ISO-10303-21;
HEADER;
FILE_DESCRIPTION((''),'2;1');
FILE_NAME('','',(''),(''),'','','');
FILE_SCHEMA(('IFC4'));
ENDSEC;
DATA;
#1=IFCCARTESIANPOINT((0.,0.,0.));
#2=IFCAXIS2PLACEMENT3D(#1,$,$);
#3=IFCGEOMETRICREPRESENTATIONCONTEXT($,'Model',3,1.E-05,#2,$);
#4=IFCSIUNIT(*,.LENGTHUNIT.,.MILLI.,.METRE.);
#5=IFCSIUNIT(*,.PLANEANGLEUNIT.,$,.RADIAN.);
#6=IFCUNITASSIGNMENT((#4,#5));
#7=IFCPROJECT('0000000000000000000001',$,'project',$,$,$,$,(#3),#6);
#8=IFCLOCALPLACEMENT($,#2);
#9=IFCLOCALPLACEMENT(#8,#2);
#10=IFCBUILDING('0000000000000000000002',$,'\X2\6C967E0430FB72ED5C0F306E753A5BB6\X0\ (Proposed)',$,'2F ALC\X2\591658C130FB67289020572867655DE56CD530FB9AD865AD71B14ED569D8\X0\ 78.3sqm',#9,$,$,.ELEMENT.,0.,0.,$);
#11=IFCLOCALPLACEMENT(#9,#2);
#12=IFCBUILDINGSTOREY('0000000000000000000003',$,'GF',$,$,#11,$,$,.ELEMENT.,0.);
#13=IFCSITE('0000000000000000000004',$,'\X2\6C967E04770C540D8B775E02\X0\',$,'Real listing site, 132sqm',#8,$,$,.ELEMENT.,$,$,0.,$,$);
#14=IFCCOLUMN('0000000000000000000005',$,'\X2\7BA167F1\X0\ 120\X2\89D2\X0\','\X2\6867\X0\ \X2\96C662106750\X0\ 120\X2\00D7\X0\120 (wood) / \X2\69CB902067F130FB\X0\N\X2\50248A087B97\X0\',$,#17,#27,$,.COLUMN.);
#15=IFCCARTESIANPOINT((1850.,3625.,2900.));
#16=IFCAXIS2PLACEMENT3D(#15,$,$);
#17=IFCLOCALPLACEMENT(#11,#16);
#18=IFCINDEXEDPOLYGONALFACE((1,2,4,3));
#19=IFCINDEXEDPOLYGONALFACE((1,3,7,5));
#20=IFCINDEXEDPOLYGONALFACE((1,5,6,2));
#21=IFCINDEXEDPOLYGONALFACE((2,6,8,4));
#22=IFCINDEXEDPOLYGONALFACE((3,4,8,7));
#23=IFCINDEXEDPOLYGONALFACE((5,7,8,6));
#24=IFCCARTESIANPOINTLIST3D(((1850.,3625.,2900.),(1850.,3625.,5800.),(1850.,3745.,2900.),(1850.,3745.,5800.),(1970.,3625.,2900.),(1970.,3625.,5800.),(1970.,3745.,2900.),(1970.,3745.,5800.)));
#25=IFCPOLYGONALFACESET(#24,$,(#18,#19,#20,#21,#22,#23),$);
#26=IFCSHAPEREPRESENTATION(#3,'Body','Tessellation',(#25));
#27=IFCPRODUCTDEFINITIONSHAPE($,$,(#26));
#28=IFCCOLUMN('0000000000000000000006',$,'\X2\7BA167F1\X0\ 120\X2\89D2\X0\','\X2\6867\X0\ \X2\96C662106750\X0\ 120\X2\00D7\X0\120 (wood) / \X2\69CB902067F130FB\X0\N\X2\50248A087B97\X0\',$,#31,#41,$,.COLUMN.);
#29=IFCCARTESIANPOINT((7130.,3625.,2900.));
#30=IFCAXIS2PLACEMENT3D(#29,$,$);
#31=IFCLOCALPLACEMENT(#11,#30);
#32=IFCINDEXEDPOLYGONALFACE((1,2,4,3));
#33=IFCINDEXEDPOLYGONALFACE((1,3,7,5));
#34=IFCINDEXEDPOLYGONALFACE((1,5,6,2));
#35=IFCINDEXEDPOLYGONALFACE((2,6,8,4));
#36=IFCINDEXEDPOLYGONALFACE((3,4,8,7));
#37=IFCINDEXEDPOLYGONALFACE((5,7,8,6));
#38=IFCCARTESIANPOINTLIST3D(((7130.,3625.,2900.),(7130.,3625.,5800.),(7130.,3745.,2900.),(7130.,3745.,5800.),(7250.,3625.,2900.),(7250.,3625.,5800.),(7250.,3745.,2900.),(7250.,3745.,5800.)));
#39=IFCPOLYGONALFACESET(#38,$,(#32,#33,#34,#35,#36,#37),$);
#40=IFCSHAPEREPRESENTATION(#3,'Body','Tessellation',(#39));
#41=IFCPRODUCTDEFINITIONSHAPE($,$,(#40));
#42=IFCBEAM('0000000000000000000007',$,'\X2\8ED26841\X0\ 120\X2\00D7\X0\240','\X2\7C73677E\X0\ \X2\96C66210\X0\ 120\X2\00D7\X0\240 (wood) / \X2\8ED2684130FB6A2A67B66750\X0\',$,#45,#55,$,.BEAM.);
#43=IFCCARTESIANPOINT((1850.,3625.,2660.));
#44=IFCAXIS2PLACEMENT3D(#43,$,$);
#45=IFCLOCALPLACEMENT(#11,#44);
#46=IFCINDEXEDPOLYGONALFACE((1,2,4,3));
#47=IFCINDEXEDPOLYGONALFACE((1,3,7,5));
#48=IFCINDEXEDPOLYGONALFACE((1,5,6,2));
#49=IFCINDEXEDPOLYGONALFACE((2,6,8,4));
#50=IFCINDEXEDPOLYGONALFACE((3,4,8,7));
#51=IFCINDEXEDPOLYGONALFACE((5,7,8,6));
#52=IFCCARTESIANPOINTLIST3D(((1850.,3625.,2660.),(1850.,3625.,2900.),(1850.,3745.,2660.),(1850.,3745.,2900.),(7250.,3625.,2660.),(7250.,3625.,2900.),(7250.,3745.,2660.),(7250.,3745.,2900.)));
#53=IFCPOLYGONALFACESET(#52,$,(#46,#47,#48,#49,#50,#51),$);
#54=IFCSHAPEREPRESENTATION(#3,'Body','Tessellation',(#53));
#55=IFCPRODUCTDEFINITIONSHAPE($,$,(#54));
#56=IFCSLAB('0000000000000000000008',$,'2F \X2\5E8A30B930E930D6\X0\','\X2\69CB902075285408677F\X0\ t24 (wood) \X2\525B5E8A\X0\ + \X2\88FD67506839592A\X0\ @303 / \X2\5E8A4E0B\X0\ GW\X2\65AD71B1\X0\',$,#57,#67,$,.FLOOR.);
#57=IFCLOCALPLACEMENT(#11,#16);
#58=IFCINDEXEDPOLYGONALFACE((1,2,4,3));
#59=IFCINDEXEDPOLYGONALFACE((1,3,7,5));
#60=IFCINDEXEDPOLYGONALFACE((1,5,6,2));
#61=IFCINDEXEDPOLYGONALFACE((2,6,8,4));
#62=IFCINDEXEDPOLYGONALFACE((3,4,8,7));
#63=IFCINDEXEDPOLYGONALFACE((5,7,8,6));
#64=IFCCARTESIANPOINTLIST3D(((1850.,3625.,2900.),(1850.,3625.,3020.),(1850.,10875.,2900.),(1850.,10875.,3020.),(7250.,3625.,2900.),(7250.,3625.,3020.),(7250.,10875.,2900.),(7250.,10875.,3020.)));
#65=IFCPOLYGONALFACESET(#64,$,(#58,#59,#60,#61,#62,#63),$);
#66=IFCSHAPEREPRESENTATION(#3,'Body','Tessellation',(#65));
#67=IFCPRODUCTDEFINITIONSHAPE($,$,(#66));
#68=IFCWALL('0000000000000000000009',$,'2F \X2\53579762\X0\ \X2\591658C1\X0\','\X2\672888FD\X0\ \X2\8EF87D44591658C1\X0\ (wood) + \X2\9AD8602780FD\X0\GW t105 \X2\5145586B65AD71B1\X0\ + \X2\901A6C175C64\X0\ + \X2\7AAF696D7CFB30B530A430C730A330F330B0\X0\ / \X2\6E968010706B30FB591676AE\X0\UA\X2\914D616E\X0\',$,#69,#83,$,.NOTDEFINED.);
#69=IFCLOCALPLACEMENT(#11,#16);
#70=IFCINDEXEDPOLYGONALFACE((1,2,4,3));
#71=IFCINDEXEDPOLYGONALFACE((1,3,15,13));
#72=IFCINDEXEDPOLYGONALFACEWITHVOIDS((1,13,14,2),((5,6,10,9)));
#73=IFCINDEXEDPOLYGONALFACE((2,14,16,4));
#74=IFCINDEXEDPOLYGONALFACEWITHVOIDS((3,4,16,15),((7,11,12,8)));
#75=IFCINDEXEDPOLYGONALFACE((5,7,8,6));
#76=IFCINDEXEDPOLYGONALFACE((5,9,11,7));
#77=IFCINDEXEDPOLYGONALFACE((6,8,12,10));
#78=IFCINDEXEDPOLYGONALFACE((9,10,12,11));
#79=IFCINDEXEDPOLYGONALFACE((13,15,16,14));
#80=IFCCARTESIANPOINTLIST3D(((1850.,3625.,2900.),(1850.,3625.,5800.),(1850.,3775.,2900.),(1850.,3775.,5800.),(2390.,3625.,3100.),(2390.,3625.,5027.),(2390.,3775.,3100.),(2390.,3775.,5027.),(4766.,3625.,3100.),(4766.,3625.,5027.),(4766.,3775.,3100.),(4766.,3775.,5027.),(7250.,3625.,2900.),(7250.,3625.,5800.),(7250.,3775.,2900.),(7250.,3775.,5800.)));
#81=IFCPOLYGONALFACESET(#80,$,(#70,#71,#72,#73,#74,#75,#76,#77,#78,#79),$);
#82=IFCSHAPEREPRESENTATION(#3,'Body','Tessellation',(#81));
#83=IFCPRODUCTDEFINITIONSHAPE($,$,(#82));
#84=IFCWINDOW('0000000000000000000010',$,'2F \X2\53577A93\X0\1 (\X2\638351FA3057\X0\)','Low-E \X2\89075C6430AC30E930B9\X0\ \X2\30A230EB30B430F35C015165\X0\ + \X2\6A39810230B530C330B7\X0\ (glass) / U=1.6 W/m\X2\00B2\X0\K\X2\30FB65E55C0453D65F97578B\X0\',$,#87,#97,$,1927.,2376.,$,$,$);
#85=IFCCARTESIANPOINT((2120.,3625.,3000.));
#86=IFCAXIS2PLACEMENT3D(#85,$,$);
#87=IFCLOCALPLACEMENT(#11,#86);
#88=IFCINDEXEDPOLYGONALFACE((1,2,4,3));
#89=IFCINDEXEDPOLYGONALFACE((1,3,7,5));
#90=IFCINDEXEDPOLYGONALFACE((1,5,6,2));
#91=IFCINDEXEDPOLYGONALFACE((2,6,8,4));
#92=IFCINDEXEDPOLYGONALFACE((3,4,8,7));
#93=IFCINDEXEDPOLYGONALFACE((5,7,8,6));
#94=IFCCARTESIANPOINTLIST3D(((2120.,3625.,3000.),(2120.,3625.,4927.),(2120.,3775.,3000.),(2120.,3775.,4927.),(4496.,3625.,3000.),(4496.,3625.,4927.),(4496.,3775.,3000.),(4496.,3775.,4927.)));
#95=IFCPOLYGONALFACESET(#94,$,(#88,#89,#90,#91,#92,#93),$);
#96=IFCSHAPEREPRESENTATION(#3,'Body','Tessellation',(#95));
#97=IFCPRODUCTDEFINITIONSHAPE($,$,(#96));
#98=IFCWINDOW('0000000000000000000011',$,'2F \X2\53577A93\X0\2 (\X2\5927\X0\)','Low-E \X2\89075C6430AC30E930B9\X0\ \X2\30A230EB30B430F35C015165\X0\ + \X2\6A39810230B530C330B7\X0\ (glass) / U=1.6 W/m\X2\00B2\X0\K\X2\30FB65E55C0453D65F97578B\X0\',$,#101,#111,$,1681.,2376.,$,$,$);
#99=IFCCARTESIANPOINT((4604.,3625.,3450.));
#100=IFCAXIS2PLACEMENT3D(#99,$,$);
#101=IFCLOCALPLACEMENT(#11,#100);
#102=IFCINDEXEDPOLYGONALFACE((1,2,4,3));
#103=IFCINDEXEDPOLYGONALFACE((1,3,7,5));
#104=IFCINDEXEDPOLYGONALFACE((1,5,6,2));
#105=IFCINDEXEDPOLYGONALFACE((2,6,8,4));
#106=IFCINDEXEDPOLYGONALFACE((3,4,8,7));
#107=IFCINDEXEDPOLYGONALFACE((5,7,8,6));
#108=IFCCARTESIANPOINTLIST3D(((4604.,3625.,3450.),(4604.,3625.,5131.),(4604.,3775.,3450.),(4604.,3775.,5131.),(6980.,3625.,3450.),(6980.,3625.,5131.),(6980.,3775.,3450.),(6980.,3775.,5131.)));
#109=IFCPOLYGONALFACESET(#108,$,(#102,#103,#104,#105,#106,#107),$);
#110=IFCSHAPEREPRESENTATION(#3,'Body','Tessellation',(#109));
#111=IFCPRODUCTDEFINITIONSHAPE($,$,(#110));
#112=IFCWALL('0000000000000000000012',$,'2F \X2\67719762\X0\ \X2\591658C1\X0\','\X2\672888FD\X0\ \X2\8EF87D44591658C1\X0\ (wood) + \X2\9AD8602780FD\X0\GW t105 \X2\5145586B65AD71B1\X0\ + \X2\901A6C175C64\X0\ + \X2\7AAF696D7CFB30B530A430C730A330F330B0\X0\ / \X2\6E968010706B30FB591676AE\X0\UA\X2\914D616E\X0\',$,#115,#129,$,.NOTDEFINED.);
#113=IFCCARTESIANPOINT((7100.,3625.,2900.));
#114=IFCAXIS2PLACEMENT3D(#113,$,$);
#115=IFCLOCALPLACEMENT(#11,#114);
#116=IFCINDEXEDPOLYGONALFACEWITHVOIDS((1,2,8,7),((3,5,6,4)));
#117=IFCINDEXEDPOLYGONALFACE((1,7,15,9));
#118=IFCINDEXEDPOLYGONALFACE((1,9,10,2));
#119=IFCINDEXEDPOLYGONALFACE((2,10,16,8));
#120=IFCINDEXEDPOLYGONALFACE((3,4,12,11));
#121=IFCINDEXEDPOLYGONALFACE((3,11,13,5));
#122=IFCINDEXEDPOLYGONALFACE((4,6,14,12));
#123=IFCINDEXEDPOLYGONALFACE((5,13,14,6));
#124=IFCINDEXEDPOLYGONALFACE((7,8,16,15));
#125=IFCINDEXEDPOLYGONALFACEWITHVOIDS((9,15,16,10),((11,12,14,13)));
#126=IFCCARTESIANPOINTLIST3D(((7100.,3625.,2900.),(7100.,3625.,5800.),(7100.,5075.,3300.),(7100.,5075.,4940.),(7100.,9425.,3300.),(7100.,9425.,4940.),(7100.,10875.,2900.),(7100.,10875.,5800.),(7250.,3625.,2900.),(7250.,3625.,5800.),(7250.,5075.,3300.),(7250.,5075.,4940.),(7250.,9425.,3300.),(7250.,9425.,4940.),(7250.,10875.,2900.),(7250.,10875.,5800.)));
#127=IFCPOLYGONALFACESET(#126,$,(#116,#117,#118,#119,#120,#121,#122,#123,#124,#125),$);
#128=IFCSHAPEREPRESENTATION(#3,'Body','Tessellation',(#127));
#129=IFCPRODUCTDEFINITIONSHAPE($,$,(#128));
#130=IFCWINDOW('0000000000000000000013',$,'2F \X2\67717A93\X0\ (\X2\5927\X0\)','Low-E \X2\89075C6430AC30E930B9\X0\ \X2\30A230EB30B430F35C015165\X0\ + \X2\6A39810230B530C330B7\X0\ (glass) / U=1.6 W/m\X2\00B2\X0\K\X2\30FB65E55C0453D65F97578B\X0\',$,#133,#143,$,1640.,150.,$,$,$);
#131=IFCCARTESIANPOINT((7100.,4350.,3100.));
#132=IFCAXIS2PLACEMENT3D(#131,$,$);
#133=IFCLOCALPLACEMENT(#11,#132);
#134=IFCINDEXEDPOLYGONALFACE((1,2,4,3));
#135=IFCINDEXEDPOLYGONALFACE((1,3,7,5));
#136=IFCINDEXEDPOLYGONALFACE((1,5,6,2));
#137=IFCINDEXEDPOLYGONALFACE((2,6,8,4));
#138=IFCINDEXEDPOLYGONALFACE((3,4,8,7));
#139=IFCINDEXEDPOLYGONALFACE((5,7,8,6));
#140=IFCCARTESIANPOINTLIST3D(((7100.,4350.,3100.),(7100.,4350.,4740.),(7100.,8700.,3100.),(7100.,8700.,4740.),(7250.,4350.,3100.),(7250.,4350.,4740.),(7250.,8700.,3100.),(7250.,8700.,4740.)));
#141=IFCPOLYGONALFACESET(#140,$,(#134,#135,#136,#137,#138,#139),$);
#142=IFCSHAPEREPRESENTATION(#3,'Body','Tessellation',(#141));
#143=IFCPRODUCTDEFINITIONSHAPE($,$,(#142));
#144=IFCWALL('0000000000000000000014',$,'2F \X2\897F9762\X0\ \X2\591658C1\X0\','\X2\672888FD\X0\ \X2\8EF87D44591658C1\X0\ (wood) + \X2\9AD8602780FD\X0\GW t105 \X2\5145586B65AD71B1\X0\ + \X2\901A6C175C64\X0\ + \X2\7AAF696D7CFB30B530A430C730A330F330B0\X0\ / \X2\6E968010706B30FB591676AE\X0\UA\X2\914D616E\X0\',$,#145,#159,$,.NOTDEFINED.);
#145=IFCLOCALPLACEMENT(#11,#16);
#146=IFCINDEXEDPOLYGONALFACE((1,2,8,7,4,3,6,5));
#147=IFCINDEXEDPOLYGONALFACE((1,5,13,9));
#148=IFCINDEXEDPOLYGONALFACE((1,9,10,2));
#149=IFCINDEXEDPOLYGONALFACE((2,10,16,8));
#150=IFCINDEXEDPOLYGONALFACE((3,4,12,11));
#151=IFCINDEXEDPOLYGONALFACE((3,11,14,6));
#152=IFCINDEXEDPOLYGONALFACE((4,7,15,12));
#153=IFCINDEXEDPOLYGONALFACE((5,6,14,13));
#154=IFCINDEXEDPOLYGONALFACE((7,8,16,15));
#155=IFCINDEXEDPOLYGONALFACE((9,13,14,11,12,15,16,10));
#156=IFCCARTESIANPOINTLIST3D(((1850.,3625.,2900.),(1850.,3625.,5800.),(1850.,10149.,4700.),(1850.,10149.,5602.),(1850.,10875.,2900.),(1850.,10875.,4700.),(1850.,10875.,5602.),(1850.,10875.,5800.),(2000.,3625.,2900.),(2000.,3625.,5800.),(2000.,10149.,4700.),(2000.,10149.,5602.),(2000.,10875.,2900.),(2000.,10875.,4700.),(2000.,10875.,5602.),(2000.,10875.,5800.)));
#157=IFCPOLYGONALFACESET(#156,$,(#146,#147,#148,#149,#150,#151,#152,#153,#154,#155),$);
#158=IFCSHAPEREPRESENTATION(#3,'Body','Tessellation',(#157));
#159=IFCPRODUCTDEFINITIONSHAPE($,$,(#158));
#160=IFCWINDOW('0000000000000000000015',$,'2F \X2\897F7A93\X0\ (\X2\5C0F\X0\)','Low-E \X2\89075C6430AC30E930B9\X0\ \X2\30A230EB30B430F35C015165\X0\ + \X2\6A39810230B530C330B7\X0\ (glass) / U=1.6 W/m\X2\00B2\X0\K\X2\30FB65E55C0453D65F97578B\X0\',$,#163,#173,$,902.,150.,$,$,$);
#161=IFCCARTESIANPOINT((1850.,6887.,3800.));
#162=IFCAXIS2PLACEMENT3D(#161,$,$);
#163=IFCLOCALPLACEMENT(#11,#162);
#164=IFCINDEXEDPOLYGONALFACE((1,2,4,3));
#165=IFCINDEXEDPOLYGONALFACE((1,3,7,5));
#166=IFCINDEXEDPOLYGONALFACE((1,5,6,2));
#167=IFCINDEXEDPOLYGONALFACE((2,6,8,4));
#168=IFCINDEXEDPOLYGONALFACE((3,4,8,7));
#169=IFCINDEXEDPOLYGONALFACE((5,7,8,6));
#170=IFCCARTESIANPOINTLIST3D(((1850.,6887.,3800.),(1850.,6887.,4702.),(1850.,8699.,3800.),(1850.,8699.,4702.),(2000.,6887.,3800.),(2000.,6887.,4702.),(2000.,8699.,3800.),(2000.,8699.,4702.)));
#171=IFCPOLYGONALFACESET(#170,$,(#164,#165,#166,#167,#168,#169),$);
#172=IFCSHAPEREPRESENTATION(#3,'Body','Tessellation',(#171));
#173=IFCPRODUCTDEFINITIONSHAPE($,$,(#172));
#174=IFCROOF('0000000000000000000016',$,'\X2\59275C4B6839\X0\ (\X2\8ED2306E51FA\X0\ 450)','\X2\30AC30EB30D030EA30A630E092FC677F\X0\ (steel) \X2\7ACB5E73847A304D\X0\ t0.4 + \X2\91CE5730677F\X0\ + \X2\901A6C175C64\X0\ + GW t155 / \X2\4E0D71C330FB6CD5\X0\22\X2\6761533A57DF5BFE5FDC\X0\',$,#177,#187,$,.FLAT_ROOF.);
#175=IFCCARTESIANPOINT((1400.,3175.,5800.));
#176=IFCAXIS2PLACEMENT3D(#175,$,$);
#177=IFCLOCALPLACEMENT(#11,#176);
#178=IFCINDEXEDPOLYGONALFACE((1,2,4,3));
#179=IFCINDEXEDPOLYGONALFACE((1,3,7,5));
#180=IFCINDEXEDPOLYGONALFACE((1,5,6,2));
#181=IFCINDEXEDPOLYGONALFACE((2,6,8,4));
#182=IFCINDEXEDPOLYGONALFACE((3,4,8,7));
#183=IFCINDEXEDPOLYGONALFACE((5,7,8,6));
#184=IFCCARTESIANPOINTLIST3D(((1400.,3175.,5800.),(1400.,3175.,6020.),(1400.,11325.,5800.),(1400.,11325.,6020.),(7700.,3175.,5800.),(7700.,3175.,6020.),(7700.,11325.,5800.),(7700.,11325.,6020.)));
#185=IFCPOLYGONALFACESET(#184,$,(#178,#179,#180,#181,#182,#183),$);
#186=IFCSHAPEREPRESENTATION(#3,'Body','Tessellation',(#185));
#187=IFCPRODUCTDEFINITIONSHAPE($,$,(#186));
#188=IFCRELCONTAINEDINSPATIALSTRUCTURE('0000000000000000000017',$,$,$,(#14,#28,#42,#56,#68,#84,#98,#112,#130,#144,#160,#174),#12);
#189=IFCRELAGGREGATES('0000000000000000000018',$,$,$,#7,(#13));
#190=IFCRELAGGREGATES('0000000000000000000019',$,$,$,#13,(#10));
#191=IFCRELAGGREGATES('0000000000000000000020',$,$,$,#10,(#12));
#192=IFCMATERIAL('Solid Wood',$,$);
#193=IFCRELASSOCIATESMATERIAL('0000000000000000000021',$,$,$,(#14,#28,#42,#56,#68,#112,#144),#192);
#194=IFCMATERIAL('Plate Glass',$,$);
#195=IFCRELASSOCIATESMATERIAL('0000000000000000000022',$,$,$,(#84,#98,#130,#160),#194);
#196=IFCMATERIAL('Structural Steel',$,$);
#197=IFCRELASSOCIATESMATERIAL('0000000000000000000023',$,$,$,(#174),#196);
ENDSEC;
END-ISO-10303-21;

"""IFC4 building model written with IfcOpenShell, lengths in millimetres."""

from ifc_helpers import new_model, si_unit, frame, frame_2d, origin, place, context, project, spatial, rectangle, extrude, material, element, fill, save


model = new_model("IFC4")

# Units and contexts
model_context = context("Model", 3, precision=1e-05, world=origin())
ifc_project = project(units=[si_unit("LENGTHUNIT", "METRE", prefix="MILLI"), si_unit("PLANEANGLEUNIT", "RADIAN")], contexts=[model_context])

# Site, building, storey
site_placement = place(None, origin())
site = spatial("IfcSite", under=ifc_project, at=site_placement, Name="沖縄県名護市", ObjectType="Real listing site, 132sqm", CompositionType="ELEMENT", RefElevation=0.0)
building_placement = place(site_placement, origin())
building = spatial("IfcBuilding", under=site, at=building_placement, Name="沖縄・狭小の町家 (Proposed)", ObjectType="2F ALC外壁・木造在来工法・高断熱仕様 78.3sqm", CompositionType="ELEMENT", ElevationOfRefHeight=0.0, ElevationOfTerrain=0.0)
storey_placement = place(building_placement, origin())
storey = spatial("IfcBuildingStorey", under=building, at=storey_placement, Name="GF", CompositionType="ELEMENT", Elevation=0.0)

# Columns
ifc_material_1 = material(Name="Solid Wood")
column_1_placement = place(storey_placement, frame((1850.0, 3625.0, 2900.0)))
element("IfcColumn", 1, at=column_1_placement, inside=storey, material=ifc_material_1, Name="管柱 120角", Description="桧 集成材 120×120 (wood) / 構造柱・N値計算", PredefinedType="COLUMN", context=model_context, shape_type="SweptSolid", body=[
    extrude(rectangle(XDim=120.0, YDim=120.0, at=frame_2d((60.0, 60.0))), frame((1850.0, 3625.0, 2900.0)), (0.0, 0.0, 1.0), 2900.0),
])
column_2_placement = place(storey_placement, frame((7130.0, 3625.0, 2900.0)))
element("IfcColumn", 2, at=column_2_placement, inside=storey, material=ifc_material_1, Name="管柱 120角", Description="桧 集成材 120×120 (wood) / 構造柱・N値計算", PredefinedType="COLUMN", context=model_context, shape_type="SweptSolid", body=[
    extrude(rectangle(XDim=120.0, YDim=120.0, at=frame_2d((60.0, 60.0))), frame((7130.0, 3625.0, 2900.0)), (0.0, 0.0, 1.0), 2900.0),
])

# Beam
beam_1_placement = place(storey_placement, frame((1850.0, 3625.0, 2660.0)))
element("IfcBeam", 3, at=beam_1_placement, inside=storey, material=ifc_material_1, Name="軒桁 120×240", Description="米松 集成 120×240 (wood) / 軒桁・横架材", PredefinedType="BEAM", context=model_context, shape_type="SweptSolid", body=[
    extrude(rectangle(XDim=5400.0, YDim=120.0, at=frame_2d((2700.0, 60.0))), frame((1850.0, 3625.0, 2660.0)), (0.0, 0.0, 1.0), 240.0),
])

# Slab
slab_placement = place(storey_placement, frame((1850.0, 3625.0, 2900.0)))
element("IfcSlab", 4, at=slab_placement, inside=storey, material=ifc_material_1, Name="2F 床スラブ", Description="構造用合板 t24 (wood) 剛床 + 製材根太 @303 / 床下 GW断熱", PredefinedType="FLOOR", context=model_context, shape_type="SweptSolid", body=[
    extrude(rectangle(XDim=5400.0, YDim=7250.0, at=frame_2d((2700.0, 3625.0))), frame((1850.0, 3625.0, 2900.0)), (0.0, 0.0, 1.0), 120.0),
])

# Wall, openings, windows
wall_1_placement = place(storey_placement, frame((1850.0, 3625.0, 2900.0)))
wall_1 = element("IfcWall", 5, at=wall_1_placement, inside=storey, material=ifc_material_1, Name="2F 南面 外壁", Description="木製 軸組外壁 (wood) + 高性能GW t105 充填断熱 + 通気層 + 窯業系サイディング / 準耐火・外皮UA配慮", PredefinedType="NOTDEFINED", context=model_context, shape_type="SweptSolid", body=[
    extrude(rectangle(XDim=5400.0, YDim=150.0, at=frame_2d((2700.0, 75.0))), frame((1850.0, 3625.0, 2900.0)), (0.0, 0.0, 1.0), 2900.0),
])
opening_1_placement = place(storey_placement, frame((2120.0, 3625.0, 3000.0)))
opening_1 = element("IfcOpeningElement", 6, at=opening_1_placement, cuts=wall_1, PredefinedType="NOTDEFINED", context=model_context, shape_type="SweptSolid", body=[
    extrude(rectangle(XDim=2376.0, YDim=150.0, at=frame_2d((1188.0, 75.0))), frame((2120.0, 3625.0, 3000.0)), (0.0, 0.0, 1.0), 1927.0),
])
opening_2_placement = place(storey_placement, frame((4604.0, 3625.0, 3450.0)))
opening_2 = element("IfcOpeningElement", 7, at=opening_2_placement, cuts=wall_1, PredefinedType="NOTDEFINED", context=model_context, shape_type="SweptSolid", body=[
    extrude(rectangle(XDim=2376.0, YDim=150.0, at=frame_2d((1188.0, 75.0))), frame((4604.0, 3625.0, 3450.0)), (0.0, 0.0, 1.0), 1681.0),
])
ifc_material_2 = material(Name="Plate Glass")
window_1_placement = place(storey_placement, frame((2120.0, 3625.0, 3000.0)))
window_1 = element("IfcWindow", 8, at=window_1_placement, inside=storey, material=ifc_material_2, Name="2F 南窓1 (掃出し)", Description="Low-E 複層ガラス アルゴン封入 + 樹脂サッシ (glass) / U=1.6 W/m²K・日射取得型", OverallHeight=1927.0, OverallWidth=2376.0, context=model_context, shape_type="SweptSolid", body=[
    extrude(rectangle(XDim=2376.0, YDim=150.0, at=frame_2d((1188.0, 75.0))), frame((2120.0, 3625.0, 3000.0)), (0.0, 0.0, 1.0), 1927.0),
])
fill(opening_1, window_1)
window_2_placement = place(storey_placement, frame((4604.0, 3625.0, 3450.0)))
window_2 = element("IfcWindow", 9, at=window_2_placement, inside=storey, material=ifc_material_2, Name="2F 南窓2 (大)", Description="Low-E 複層ガラス アルゴン封入 + 樹脂サッシ (glass) / U=1.6 W/m²K・日射取得型", OverallHeight=1681.0, OverallWidth=2376.0, context=model_context, shape_type="SweptSolid", body=[
    extrude(rectangle(XDim=2376.0, YDim=150.0, at=frame_2d((1188.0, 75.0))), frame((4604.0, 3625.0, 3450.0)), (0.0, 0.0, 1.0), 1681.0),
])
fill(opening_2, window_2)

# Walls, openings, windows
wall_2_placement = place(storey_placement, frame((7100.0, 3625.0, 2900.0)))
wall_2 = element("IfcWall", 10, at=wall_2_placement, inside=storey, material=ifc_material_1, Name="2F 東面 外壁", Description="木製 軸組外壁 (wood) + 高性能GW t105 充填断熱 + 通気層 + 窯業系サイディング / 準耐火・外皮UA配慮", PredefinedType="NOTDEFINED", context=model_context, shape_type="SweptSolid", body=[
    extrude(rectangle(XDim=150.0, YDim=7250.0, at=frame_2d((75.0, 3625.0))), frame((7100.0, 3625.0, 2900.0)), (0.0, 0.0, 1.0), 2900.0),
])
opening_3_placement = place(storey_placement, frame((7100.0, 4350.0, 3100.0)))
opening_3 = element("IfcOpeningElement", 11, at=opening_3_placement, cuts=wall_2, PredefinedType="NOTDEFINED", context=model_context, shape_type="SweptSolid", body=[
    extrude(rectangle(XDim=150.0, YDim=4350.0, at=frame_2d((75.0, 2175.0))), frame((7100.0, 4350.0, 3100.0)), (0.0, 0.0, 1.0), 1640.0),
])
window_3_placement = place(storey_placement, frame((7100.0, 4350.0, 3100.0)))
window_3 = element("IfcWindow", 12, at=window_3_placement, inside=storey, material=ifc_material_2, Name="2F 東窓 (大)", Description="Low-E 複層ガラス アルゴン封入 + 樹脂サッシ (glass) / U=1.6 W/m²K・日射取得型", OverallHeight=1640.0, OverallWidth=150.0, context=model_context, shape_type="SweptSolid", body=[
    extrude(rectangle(XDim=150.0, YDim=4350.0, at=frame_2d((75.0, 2175.0))), frame((7100.0, 4350.0, 3100.0)), (0.0, 0.0, 1.0), 1640.0),
])
fill(opening_3, window_3)
wall_3_placement = place(storey_placement, frame((1850.0, 3625.0, 2900.0)))
wall_3 = element("IfcWall", 13, at=wall_3_placement, inside=storey, material=ifc_material_1, Name="2F 西面 外壁", Description="木製 軸組外壁 (wood) + 高性能GW t105 充填断熱 + 通気層 + 窯業系サイディング / 準耐火・外皮UA配慮", PredefinedType="NOTDEFINED", context=model_context, shape_type="SweptSolid", body=[
    extrude(rectangle(XDim=150.0, YDim=7250.0, at=frame_2d((75.0, 3625.0))), frame((1850.0, 3625.0, 2900.0)), (0.0, 0.0, 1.0), 2900.0),
])
opening_4_placement = place(storey_placement, frame((1850.0, 6887.0, 3800.0)))
opening_4 = element("IfcOpeningElement", 14, at=opening_4_placement, cuts=wall_3, PredefinedType="NOTDEFINED", context=model_context, shape_type="SweptSolid", body=[
    extrude(rectangle(XDim=150.0, YDim=1812.0, at=frame_2d((75.0, 906.0))), frame((1850.0, 6887.0, 3800.0)), (0.0, 0.0, 1.0), 902.0),
])
window_4_placement = place(storey_placement, frame((1850.0, 6887.0, 3800.0)))
window_4 = element("IfcWindow", 15, at=window_4_placement, inside=storey, material=ifc_material_2, Name="2F 西窓 (小)", Description="Low-E 複層ガラス アルゴン封入 + 樹脂サッシ (glass) / U=1.6 W/m²K・日射取得型", OverallHeight=902.0, OverallWidth=150.0, context=model_context, shape_type="SweptSolid", body=[
    extrude(rectangle(XDim=150.0, YDim=1812.0, at=frame_2d((75.0, 906.0))), frame((1850.0, 6887.0, 3800.0)), (0.0, 0.0, 1.0), 902.0),
])
fill(opening_4, window_4)

# Roof
ifc_material_3 = material(Name="Structural Steel")
roof_placement = place(storey_placement, frame((1400.0, 3175.0, 5800.0)))
element("IfcRoof", 16, at=roof_placement, inside=storey, material=ifc_material_3, Name="大屋根 (軒の出 450)", Description="ガルバリウム鋼板 (steel) 立平葺き t0.4 + 野地板 + 通気層 + GW t155 / 不燃・法22条区域対応", PredefinedType="FLAT_ROOF", context=model_context, shape_type="SweptSolid", body=[
    extrude(rectangle(XDim=6300.0, YDim=8150.0, at=frame_2d((3150.0, 4075.0))), frame((1400.0, 3175.0, 5800.0)), (0.0, 0.0, 1.0), 220.0),
])

save(model, "model.ifc")
